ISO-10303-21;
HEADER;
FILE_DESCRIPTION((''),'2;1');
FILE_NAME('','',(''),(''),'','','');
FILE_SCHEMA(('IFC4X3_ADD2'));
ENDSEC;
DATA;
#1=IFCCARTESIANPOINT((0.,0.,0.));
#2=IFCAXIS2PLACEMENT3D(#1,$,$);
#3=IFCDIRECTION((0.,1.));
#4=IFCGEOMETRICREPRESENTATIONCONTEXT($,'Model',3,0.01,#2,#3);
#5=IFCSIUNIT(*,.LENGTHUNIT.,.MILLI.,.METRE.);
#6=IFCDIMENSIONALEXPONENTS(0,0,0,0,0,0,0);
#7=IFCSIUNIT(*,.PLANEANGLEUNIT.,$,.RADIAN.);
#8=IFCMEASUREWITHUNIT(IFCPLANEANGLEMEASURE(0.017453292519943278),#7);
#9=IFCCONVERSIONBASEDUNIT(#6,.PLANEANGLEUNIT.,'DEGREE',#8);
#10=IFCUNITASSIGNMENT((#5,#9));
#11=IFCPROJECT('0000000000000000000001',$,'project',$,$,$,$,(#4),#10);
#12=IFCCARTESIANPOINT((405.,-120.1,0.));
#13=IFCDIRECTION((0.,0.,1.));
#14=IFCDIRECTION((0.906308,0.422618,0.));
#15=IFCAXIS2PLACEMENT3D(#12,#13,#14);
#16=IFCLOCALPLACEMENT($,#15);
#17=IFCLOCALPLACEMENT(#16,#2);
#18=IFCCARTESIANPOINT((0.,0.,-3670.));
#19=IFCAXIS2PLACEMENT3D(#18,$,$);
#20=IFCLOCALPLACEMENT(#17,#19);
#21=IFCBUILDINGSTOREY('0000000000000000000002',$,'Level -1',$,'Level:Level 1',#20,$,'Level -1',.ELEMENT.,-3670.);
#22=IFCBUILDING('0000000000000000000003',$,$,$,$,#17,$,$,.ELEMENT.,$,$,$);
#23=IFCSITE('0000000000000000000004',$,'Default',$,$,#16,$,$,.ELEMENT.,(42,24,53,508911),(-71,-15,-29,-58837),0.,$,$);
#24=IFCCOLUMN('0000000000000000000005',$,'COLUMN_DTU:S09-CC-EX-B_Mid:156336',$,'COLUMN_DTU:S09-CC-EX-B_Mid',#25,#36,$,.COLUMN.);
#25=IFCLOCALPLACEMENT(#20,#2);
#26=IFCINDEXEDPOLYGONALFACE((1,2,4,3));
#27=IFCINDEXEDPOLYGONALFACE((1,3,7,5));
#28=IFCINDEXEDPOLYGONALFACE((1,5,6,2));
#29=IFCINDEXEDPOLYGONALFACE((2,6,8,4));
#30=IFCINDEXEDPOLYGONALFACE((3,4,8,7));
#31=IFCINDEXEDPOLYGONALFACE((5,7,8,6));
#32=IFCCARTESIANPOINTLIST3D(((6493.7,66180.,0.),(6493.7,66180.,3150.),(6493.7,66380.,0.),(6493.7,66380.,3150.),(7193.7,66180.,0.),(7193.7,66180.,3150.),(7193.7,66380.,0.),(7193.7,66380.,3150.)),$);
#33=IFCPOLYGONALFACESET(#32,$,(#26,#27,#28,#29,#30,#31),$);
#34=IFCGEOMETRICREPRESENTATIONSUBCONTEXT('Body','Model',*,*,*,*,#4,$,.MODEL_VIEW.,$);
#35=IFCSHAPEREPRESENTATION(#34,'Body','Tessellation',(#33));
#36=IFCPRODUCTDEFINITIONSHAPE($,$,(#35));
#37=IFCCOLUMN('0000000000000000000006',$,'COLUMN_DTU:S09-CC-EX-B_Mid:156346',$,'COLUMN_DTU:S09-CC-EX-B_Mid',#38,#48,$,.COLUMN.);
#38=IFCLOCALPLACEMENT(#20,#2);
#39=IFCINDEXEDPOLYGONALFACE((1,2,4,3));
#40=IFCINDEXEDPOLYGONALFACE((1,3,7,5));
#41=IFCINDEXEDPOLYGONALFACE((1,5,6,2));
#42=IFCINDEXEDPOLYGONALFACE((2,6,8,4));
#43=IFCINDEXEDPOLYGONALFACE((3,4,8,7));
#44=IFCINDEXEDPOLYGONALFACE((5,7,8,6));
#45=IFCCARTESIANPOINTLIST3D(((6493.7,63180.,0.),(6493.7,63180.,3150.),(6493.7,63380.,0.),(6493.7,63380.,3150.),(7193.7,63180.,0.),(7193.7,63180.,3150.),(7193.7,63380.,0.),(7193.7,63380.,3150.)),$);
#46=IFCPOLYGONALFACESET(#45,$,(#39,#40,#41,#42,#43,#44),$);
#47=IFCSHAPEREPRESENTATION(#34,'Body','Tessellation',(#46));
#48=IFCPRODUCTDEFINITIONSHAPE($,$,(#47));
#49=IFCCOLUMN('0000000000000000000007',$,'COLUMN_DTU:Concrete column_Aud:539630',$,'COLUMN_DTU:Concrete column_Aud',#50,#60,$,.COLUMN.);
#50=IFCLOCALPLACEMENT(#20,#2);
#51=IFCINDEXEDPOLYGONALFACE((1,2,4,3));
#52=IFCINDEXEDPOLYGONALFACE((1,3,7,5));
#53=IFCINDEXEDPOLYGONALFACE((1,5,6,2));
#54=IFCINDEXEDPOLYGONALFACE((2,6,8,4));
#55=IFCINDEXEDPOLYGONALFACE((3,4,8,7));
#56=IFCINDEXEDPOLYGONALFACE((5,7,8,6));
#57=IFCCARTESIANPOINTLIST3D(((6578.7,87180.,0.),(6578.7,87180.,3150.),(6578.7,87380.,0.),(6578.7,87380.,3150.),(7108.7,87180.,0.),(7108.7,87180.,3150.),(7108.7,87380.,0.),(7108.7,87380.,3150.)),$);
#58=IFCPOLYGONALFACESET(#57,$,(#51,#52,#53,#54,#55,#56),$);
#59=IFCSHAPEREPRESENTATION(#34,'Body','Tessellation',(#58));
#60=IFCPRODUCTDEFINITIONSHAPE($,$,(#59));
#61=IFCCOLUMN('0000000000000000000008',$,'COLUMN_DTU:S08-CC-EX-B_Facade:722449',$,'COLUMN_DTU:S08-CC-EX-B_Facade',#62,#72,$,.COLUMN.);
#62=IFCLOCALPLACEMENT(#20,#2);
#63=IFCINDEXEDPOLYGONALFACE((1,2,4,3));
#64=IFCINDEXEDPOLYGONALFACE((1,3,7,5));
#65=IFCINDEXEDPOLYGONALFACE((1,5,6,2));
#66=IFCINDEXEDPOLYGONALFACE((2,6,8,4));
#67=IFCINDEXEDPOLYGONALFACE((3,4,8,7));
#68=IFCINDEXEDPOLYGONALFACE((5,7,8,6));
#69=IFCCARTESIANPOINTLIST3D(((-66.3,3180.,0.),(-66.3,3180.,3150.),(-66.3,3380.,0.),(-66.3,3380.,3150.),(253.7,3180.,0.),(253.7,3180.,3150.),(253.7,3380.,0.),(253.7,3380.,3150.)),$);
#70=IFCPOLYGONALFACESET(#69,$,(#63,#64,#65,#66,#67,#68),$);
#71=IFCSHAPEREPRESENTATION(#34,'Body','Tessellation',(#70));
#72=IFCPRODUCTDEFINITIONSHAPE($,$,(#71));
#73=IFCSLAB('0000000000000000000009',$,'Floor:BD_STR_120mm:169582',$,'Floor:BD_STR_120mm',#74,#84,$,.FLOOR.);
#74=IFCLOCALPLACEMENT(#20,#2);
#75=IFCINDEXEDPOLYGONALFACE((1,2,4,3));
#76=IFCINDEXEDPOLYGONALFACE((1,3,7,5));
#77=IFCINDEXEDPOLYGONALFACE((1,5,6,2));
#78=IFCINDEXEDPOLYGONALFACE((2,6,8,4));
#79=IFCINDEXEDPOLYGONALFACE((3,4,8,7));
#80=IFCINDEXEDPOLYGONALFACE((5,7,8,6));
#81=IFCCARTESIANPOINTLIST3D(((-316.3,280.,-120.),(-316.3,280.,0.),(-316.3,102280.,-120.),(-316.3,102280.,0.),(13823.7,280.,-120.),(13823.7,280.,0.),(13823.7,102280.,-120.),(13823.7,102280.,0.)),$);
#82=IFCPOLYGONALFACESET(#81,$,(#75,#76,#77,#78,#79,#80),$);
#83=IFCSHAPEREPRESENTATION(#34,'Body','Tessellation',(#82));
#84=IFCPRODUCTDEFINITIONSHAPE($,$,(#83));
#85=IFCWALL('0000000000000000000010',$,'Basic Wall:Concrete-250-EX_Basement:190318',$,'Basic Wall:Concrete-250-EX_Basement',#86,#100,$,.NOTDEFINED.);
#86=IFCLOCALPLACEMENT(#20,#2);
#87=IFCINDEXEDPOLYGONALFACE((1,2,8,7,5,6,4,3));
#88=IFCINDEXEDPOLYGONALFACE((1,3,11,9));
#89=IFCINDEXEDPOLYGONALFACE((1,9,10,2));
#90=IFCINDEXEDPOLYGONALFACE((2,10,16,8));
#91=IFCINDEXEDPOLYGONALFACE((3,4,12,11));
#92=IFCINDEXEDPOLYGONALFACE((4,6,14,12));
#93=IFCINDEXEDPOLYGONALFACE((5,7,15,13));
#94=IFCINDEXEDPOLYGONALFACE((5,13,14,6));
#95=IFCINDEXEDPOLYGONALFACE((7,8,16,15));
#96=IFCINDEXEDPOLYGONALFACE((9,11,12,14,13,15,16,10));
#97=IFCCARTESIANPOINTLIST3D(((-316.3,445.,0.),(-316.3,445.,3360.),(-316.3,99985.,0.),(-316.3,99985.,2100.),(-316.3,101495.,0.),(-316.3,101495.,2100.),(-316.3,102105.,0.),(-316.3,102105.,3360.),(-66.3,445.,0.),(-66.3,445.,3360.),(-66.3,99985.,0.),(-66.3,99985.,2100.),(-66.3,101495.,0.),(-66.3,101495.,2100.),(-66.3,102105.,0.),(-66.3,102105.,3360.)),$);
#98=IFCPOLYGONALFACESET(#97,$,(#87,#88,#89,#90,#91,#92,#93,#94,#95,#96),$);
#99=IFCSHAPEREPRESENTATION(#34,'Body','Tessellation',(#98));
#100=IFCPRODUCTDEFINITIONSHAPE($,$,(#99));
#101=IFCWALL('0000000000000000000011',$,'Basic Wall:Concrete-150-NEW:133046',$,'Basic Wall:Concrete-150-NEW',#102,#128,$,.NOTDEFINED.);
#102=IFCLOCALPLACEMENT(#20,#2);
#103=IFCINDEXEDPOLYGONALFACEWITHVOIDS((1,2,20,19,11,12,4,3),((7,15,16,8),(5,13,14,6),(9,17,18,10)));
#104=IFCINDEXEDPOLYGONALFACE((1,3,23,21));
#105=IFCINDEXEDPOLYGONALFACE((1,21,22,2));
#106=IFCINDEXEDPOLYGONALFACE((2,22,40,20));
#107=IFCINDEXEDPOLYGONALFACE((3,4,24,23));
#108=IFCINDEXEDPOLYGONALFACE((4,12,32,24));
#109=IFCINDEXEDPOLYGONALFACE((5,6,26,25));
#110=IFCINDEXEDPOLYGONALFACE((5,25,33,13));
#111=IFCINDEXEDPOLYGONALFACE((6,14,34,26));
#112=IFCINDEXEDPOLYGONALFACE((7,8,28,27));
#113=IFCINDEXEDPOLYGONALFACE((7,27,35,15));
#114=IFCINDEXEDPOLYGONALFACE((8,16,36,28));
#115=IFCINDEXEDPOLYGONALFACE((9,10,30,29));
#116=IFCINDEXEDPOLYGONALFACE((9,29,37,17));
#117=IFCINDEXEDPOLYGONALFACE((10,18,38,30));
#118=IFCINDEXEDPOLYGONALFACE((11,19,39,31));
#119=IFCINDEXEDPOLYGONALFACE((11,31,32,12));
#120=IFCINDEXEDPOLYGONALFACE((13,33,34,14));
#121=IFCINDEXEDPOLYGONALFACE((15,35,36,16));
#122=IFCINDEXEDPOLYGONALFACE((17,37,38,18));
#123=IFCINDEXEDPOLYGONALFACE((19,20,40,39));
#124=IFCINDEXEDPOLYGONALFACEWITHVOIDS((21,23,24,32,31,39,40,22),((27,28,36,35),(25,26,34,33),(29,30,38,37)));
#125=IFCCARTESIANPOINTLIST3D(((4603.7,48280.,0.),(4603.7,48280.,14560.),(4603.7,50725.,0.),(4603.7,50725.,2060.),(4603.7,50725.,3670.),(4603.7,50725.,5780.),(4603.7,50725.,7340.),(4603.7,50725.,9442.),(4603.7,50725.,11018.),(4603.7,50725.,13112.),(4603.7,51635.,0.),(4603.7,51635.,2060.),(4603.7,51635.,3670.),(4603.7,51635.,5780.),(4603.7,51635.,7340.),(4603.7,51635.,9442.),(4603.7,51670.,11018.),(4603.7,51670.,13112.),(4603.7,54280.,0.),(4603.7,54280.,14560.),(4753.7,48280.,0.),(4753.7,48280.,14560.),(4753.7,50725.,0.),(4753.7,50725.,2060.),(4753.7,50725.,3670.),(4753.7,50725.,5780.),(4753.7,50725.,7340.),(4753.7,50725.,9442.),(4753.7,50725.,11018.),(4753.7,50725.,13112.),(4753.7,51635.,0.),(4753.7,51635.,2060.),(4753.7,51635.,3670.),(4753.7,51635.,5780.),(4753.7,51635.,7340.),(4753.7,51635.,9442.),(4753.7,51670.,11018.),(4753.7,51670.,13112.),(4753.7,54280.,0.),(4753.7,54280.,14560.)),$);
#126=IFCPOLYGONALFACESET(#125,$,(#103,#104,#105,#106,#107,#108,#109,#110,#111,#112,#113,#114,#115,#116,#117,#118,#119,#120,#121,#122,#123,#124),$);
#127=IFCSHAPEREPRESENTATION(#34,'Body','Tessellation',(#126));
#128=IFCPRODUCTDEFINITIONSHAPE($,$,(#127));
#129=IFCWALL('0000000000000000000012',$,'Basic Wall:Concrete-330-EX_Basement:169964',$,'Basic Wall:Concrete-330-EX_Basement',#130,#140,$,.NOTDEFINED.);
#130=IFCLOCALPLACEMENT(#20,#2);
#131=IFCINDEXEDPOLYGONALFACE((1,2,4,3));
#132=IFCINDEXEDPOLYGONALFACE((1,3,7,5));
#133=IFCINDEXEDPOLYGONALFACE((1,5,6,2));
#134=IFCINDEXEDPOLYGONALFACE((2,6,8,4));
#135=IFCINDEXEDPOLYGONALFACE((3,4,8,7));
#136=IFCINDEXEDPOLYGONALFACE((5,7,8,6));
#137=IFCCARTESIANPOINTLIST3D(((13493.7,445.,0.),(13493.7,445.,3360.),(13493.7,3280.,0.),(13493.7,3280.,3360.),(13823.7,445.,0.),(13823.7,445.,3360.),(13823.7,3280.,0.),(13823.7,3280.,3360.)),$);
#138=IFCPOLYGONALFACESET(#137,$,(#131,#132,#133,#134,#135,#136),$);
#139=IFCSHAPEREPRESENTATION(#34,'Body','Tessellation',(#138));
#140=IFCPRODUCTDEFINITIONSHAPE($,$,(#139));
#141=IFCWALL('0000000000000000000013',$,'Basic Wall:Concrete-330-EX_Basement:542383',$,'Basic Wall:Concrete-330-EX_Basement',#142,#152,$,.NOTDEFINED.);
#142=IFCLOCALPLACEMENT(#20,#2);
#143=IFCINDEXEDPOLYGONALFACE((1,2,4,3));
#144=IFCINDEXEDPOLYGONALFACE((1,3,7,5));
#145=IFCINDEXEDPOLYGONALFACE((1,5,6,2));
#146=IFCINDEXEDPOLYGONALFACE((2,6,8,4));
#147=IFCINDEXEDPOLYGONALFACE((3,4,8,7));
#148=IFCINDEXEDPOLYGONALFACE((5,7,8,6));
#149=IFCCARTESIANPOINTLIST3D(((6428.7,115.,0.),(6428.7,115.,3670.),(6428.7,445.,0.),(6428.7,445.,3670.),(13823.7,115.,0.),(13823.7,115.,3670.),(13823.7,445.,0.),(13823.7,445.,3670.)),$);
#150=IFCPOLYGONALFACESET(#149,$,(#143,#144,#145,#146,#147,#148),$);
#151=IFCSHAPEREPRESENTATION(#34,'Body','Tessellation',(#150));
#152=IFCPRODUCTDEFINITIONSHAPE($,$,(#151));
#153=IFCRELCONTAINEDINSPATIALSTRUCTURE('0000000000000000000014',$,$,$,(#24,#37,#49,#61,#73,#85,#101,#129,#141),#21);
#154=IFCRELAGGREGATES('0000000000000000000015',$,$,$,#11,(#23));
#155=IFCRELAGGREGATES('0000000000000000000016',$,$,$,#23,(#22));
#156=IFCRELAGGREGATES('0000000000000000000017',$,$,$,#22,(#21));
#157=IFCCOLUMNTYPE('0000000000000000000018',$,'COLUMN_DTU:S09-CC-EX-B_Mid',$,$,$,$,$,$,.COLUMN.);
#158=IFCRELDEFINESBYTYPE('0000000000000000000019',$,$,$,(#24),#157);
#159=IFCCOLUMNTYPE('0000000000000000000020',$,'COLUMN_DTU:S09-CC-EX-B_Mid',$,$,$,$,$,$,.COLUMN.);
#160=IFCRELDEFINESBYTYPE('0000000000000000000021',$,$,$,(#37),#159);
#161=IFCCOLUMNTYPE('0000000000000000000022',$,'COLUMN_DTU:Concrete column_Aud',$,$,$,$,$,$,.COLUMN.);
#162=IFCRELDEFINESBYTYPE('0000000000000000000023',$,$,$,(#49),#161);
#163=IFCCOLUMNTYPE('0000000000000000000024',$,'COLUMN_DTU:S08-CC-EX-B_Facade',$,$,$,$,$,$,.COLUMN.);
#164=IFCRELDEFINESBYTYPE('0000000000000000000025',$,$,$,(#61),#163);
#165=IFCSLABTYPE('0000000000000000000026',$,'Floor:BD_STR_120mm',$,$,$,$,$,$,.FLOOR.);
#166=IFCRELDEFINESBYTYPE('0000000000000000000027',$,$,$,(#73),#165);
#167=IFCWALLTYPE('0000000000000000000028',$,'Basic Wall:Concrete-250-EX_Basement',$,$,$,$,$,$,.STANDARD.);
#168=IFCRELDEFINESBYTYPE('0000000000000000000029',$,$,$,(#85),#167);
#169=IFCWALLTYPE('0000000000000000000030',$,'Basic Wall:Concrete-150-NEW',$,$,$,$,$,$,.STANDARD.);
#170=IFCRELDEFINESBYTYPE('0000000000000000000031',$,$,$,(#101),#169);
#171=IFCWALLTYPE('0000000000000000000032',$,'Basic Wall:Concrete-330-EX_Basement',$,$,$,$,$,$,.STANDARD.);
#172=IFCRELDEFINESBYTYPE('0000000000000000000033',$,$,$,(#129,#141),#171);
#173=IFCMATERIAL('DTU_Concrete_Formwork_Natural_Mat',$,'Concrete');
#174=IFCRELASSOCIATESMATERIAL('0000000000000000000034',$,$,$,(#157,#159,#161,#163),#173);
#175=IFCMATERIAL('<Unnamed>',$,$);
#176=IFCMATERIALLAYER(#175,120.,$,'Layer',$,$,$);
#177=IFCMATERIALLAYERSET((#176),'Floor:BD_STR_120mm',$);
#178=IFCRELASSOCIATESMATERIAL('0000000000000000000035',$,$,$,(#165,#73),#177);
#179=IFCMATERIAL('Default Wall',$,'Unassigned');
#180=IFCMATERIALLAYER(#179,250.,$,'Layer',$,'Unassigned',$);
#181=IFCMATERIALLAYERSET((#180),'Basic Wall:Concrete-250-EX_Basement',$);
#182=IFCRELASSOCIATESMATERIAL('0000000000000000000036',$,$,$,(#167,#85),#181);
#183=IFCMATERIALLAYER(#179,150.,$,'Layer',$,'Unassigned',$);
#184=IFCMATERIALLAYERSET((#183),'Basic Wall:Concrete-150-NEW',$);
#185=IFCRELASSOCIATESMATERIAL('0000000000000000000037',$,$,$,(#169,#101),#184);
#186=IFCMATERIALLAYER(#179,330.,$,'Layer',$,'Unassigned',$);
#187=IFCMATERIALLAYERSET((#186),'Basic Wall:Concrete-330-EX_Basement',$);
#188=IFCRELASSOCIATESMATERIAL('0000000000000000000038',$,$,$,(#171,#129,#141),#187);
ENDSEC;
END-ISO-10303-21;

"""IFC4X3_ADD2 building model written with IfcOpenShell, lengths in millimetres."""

from ifc_helpers import new_model, entity, si_unit, converted_unit, direction, frame, frame_2d, origin, origin_2d_with_axis, place, context, subcontext, project, spatial, rectangle, extrude, source, transform, mapped, material, layer, layer_set, layer_usage, material_profile, profile_set, type_object, type_shapes, element, save


model = new_model("IFC4X3_ADD2")

# Units and contexts
model_context = context("Model", 3, precision=0.01, world=origin(), true_north=direction((0.0, 1.0)))
body_context = subcontext(model_context, "Body", "Model", "MODEL_VIEW")
ifc_project = project(units=[si_unit("LENGTHUNIT", "METRE", prefix="MILLI"), converted_unit("PLANEANGLEUNIT", "DEGREE", entity("IfcPlaneAngleMeasure", 0.017453292519943278), si_unit("PLANEANGLEUNIT", "RADIAN"), dimensions=[0, 0, 0, 0, 0, 0, 0])], contexts=[model_context])

# Site, building, storey
site_placement = place(None, frame((405.0, -120.1, 0.0), z_axis=(0.0, 0.0, 1.0), x_axis=(0.906308, 0.422618, 0.0)))
site = spatial("IfcSite", under=ifc_project, at=site_placement, Name="Default", CompositionType="ELEMENT", RefLatitude=(42, 24, 53, 508911), RefLongitude=(-71, -15, -29, -58837), RefElevation=0.0)
building_placement = place(site_placement, origin())
building = spatial("IfcBuilding", under=site, at=building_placement, CompositionType="ELEMENT")
storey_placement = place(building_placement, frame((0.0, 0.0, -3670.0)))
storey = spatial("IfcBuildingStorey", under=building, at=storey_placement, Name="Level -1", ObjectType="Level:Level 1", LongName="Level -1", CompositionType="ELEMENT", Elevation=-3670.0)

# Columns
ifc_material_1 = material(Name="DTU_Concrete_Formwork_Natural_Mat", Category="Concrete")
ifc_material_profile_1 = material_profile(ifc_material_1, rectangle(XDim=200.0, YDim=700.0, at=frame_2d((0.0, 0.0), x_axis=(1.0, 0.0))), Name="S09-CC-EX-B_Mid")
ifc_profile_set_1 = profile_set([ifc_material_profile_1], Name="S09-CC-EX-B_Mid")
column_type_1 = type_object("IfcColumnType", Name="COLUMN_DTU:S09-CC-EX-B_Mid", PredefinedType="COLUMN", material=ifc_profile_set_1)
shared_shape_1 = source(origin(), body_context, "Body", "SweptSolid", [
    extrude(rectangle(XDim=200.0, YDim=700.0, at=frame_2d((0.0, 0.0), x_axis=(1.0, 0.0))), frame((6843.7, 66280.0, -3670.0), z_axis=(0.0, 0.0, 1.0), x_axis=(0.0, 1.0, 0.0)), (0.0, 0.0, 1.0), 3150.0),
])
type_shapes(column_type_1, [shared_shape_1])
column_1_placement = place(storey_placement, frame((0.0, 0.0, 3670.0)))
element("IfcColumn", 1, at=column_1_placement, inside=storey, type_object=column_type_1, Name="COLUMN_DTU:S09-CC-EX-B_Mid:156336", ObjectType="COLUMN_DTU:S09-CC-EX-B_Mid", PredefinedType="COLUMN", context=body_context, shape_type="MappedRepresentation", body=[
    mapped(shared_shape_1, transform((0.0, 0.0, 0.0), scale=1.0)),
])
column_type_2 = type_object("IfcColumnType", Name="COLUMN_DTU:S09-CC-EX-B_Mid", PredefinedType="COLUMN", material=ifc_profile_set_1)
shared_shape_2 = source(origin(), body_context, "Body", "SweptSolid", [
    extrude(rectangle(XDim=200.0, YDim=700.0, at=frame_2d((0.0, 0.0), x_axis=(1.0, 0.0))), frame((6843.7, 63280.0, -3670.0), z_axis=(0.0, 0.0, 1.0), x_axis=(0.0, 1.0, 0.0)), (0.0, 0.0, 1.0), 3150.0),
])
type_shapes(column_type_2, [shared_shape_2])
column_2_placement = place(storey_placement, frame((0.0, 0.0, 3670.0)))
element("IfcColumn", 2, at=column_2_placement, inside=storey, type_object=column_type_2, Name="COLUMN_DTU:S09-CC-EX-B_Mid:156346", ObjectType="COLUMN_DTU:S09-CC-EX-B_Mid", PredefinedType="COLUMN", context=body_context, shape_type="MappedRepresentation", body=[
    mapped(shared_shape_2, transform((0.0, 0.0, 0.0), scale=1.0)),
])
ifc_material_profile_2 = material_profile(ifc_material_1, rectangle(XDim=200.0, YDim=530.0, at=frame_2d((0.0, 0.0), x_axis=(1.0, 0.0))), Name="Concrete column_Aud")
ifc_profile_set_2 = profile_set([ifc_material_profile_2], Name="Concrete column_Aud")
column_type_3 = type_object("IfcColumnType", Name="COLUMN_DTU:Concrete column_Aud", PredefinedType="COLUMN", material=ifc_profile_set_2)
shared_shape_3 = source(origin(), body_context, "Body", "SweptSolid", [
    extrude(rectangle(XDim=200.0, YDim=530.0, at=frame_2d((0.0, 0.0), x_axis=(1.0, 0.0))), frame((6843.7, 87280.0, -3670.0), z_axis=(0.0, 0.0, 1.0), x_axis=(0.0, 1.0, 0.0)), (0.0, 0.0, 1.0), 3150.0),
])
type_shapes(column_type_3, [shared_shape_3])
column_3_placement = place(storey_placement, frame((0.0, 0.0, 3670.0)))
element("IfcColumn", 3, at=column_3_placement, inside=storey, type_object=column_type_3, Name="COLUMN_DTU:Concrete column_Aud:539630", ObjectType="COLUMN_DTU:Concrete column_Aud", PredefinedType="COLUMN", context=body_context, shape_type="MappedRepresentation", body=[
    mapped(shared_shape_3, transform((0.0, 0.0, 0.0), scale=1.0)),
])
ifc_material_profile_3 = material_profile(ifc_material_1, rectangle(XDim=200.0, YDim=320.0, at=origin_2d_with_axis()), Name="S08-CC-EX-B_Facade")
ifc_profile_set_3 = profile_set([ifc_material_profile_3], Name="S08-CC-EX-B_Facade")
column_type_4 = type_object("IfcColumnType", Name="COLUMN_DTU:S08-CC-EX-B_Facade", PredefinedType="COLUMN", material=ifc_profile_set_3)
shared_shape_4 = source(origin(), body_context, "Body", "SweptSolid", [
    extrude(rectangle(XDim=200.0, YDim=320.0, at=origin_2d_with_axis()), frame((93.7, 3280.0, -3670.0), z_axis=(0.0, 0.0, 1.0), x_axis=(0.0, 1.0, 0.0)), (0.0, 0.0, 1.0), 3150.0),
])
type_shapes(column_type_4, [shared_shape_4])
column_4_placement = place(storey_placement, frame((0.0, 0.0, 3670.0)))
element("IfcColumn", 4, at=column_4_placement, inside=storey, type_object=column_type_4, Name="COLUMN_DTU:S08-CC-EX-B_Facade:722449", ObjectType="COLUMN_DTU:S08-CC-EX-B_Facade", PredefinedType="COLUMN", context=body_context, shape_type="MappedRepresentation", body=[
    mapped(shared_shape_4, transform((0.0, 0.0, 0.0), scale=1.0)),
])

# Slab
ifc_material_2 = material(Name="<Unnamed>")
ifc_layer_1 = layer(ifc_material_2, 120.0, Name="Layer")
ifc_layer_set_1 = layer_set([ifc_layer_1], Name="Floor:BD_STR_120mm")
ifc_layer_usage = layer_usage(ifc_layer_set_1, "AXIS3", "POSITIVE", 0.0)
slab_type = type_object("IfcSlabType", Name="Floor:BD_STR_120mm", PredefinedType="FLOOR", material=ifc_layer_set_1)
slab_placement = place(storey_placement, origin())
element("IfcSlab", 5, at=slab_placement, inside=storey, type_object=slab_type, material=ifc_layer_usage, Name="Floor:BD_STR_120mm:169582", ObjectType="Floor:BD_STR_120mm", PredefinedType="FLOOR", context=body_context, shape_type="SweptSolid", body=[
    extrude(rectangle(XDim=102000.0, YDim=14140.0, at=origin_2d_with_axis()), frame((6753.7, 51280.0, 0.0), z_axis=(0.0, 0.0, -1.0), x_axis=(0.0, 1.0, 0.0)), (0.0, 0.0, 1.0), 120.0),
])

# Wall, opening
ifc_material_3 = material(Name="Default Wall", Category="Unassigned")
ifc_layer_2 = layer(ifc_material_3, 250.0, Name="Layer", Category="Unassigned")
ifc_layer_set_2 = layer_set([ifc_layer_2], Name="Basic Wall:Concrete-250-EX_Basement")
wall_type_1 = type_object("IfcWallType", Name="Basic Wall:Concrete-250-EX_Basement", PredefinedType="STANDARD", material=ifc_layer_set_2)
wall_1_placement = place(storey_placement, frame((-191.3, 445.0, 0.0), z_axis=(0.0, 0.0, 1.0), x_axis=(0.0, 1.0, 0.0)))
wall_1 = element("IfcWall", 6, at=wall_1_placement, inside=storey, type_object=wall_type_1, material=ifc_layer_set_2, Name="Basic Wall:Concrete-250-EX_Basement:190318", ObjectType="Basic Wall:Concrete-250-EX_Basement", PredefinedType="NOTDEFINED", context=body_context, shape_type="SweptSolid", body=[
    extrude(rectangle(XDim=101660.0, YDim=250.0, at=frame_2d((50830.0, 0.0), x_axis=(1.0, 0.0))), origin(), (0.0, 0.0, 1.0), 3360.0),
])
opening_1_placement = place(wall_1_placement, frame((99540.0, 125.0, 0.0)))
element("IfcOpeningElement", 7, at=opening_1_placement, cuts=wall_1, PredefinedType="OPENING", context=body_context, shape_type="SweptSolid", body=[
    extrude(rectangle(XDim=2100.0, YDim=1510.0, at=frame_2d((0.0, 0.0), x_axis=(1.0, 0.0))), frame((755.0, -250.0, 1050.0), z_axis=(0.0, 1.0, 0.0), x_axis=(0.0, 0.0, -1.0)), (0.0, 0.0, 1.0), 250.0),
])

# Wall, openings
ifc_layer_3 = layer(ifc_material_3, 150.0, Name="Layer", Category="Unassigned")
ifc_layer_set_3 = layer_set([ifc_layer_3], Name="Basic Wall:Concrete-150-NEW")
wall_type_2 = type_object("IfcWallType", Name="Basic Wall:Concrete-150-NEW", PredefinedType="STANDARD", material=ifc_layer_set_3)
wall_2_placement = place(storey_placement, frame((4678.7, 48280.0, 0.0), z_axis=(0.0, 0.0, 1.0), x_axis=(0.0, 1.0, 0.0)))
wall_2 = element("IfcWall", 8, at=wall_2_placement, inside=storey, type_object=wall_type_2, material=ifc_layer_set_3, Name="Basic Wall:Concrete-150-NEW:133046", ObjectType="Basic Wall:Concrete-150-NEW", PredefinedType="NOTDEFINED", context=body_context, shape_type="SweptSolid", body=[
    extrude(rectangle(XDim=6000.0, YDim=150.0, at=frame_2d((3000.0, 0.0), x_axis=(-1.0, 0.0))), origin(), (0.0, 0.0, 1.0), 14560.0),
])
opening_2_placement = place(wall_2_placement, origin())
element("IfcOpeningElement", 9, at=opening_2_placement, cuts=wall_2, PredefinedType="OPENING", context=body_context, shape_type="SweptSolid", body=[
    extrude(rectangle(XDim=2094.0, YDim=945.0, at=frame_2d((0.0, 0.0), x_axis=(1.0, 0.0))), frame((2917.5, 75.0, 12065.0), z_axis=(0.0, -1.0, 0.0), x_axis=(0.0, 0.0, 1.0)), (0.0, 0.0, 1.0), 150.0),
])
opening_3_placement = place(wall_2_placement, origin())
element("IfcOpeningElement", 10, at=opening_3_placement, cuts=wall_2, PredefinedType="OPENING", context=body_context, shape_type="SweptSolid", body=[
    extrude(rectangle(XDim=2102.0, YDim=910.0, at=frame_2d((0.0, 0.0), x_axis=(0.0, 1.0))), frame((2900.0, 75.0, 8391.0), z_axis=(0.0, -1.0, 0.0), x_axis=(-1.0, 0.0, 0.0)), (0.0, 0.0, 1.0), 150.0),
])
opening_4_placement = place(wall_2_placement, origin())
element("IfcOpeningElement", 11, at=opening_4_placement, cuts=wall_2, PredefinedType="OPENING", context=body_context, shape_type="SweptSolid", body=[
    extrude(rectangle(XDim=2110.0, YDim=910.0, at=frame_2d((0.0, 0.0), x_axis=(0.0, 1.0))), frame((2900.0, 75.0, 4725.0), z_axis=(0.0, -1.0, 0.0), x_axis=(-1.0, 0.0, 0.0)), (0.0, 0.0, 1.0), 150.0),
])
opening_5_placement = place(wall_2_placement, origin())
element("IfcOpeningElement", 12, at=opening_5_placement, cuts=wall_2, PredefinedType="OPENING", context=body_context, shape_type="SweptSolid", body=[
    extrude(rectangle(XDim=2060.0, YDim=910.0, at=frame_2d((0.0, 0.0), x_axis=(0.0, 1.0))), frame((2900.0, 75.0, 1030.0), z_axis=(0.0, -1.0, 0.0), x_axis=(1.0, 0.0, 0.0)), (0.0, 0.0, 1.0), 150.0),
])

# Walls
ifc_layer_4 = layer(ifc_material_3, 330.0, Name="Layer", Category="Unassigned")
ifc_layer_set_4 = layer_set([ifc_layer_4], Name="Basic Wall:Concrete-330-EX_Basement")
wall_type_3 = type_object("IfcWallType", Name="Basic Wall:Concrete-330-EX_Basement", PredefinedType="STANDARD", material=ifc_layer_set_4)
wall_3_placement = place(storey_placement, frame((13658.7, 3280.0, 0.0), z_axis=(0.0, 0.0, 1.0), x_axis=(0.0, -1.0, 0.0)))
element("IfcWall", 13, at=wall_3_placement, inside=storey, type_object=wall_type_3, material=ifc_layer_set_4, Name="Basic Wall:Concrete-330-EX_Basement:169964", ObjectType="Basic Wall:Concrete-330-EX_Basement", PredefinedType="NOTDEFINED", context=body_context, shape_type="SweptSolid", body=[
    extrude(rectangle(XDim=2835.0, YDim=330.0, at=frame_2d((1417.5, 0.0), x_axis=(-1.0, 0.0))), origin(), (0.0, 0.0, 1.0), 3360.0),
])
wall_4_placement = place(storey_placement, frame((13823.7, 280.0, 0.0), z_axis=(0.0, 0.0, 1.0), x_axis=(-1.0, 0.0, 0.0)))
element("IfcWall", 14, at=wall_4_placement, inside=storey, type_object=wall_type_3, material=ifc_layer_set_4, Name="Basic Wall:Concrete-330-EX_Basement:542383", ObjectType="Basic Wall:Concrete-330-EX_Basement", PredefinedType="NOTDEFINED", context=body_context, shape_type="SweptSolid", body=[
    extrude(rectangle(XDim=7395.0, YDim=330.0, at=frame_2d((3697.5, 0.0), x_axis=(-1.0, 0.0))), origin(), (0.0, 0.0, 1.0), 3670.0),
])

save(model, "model.ifc")
